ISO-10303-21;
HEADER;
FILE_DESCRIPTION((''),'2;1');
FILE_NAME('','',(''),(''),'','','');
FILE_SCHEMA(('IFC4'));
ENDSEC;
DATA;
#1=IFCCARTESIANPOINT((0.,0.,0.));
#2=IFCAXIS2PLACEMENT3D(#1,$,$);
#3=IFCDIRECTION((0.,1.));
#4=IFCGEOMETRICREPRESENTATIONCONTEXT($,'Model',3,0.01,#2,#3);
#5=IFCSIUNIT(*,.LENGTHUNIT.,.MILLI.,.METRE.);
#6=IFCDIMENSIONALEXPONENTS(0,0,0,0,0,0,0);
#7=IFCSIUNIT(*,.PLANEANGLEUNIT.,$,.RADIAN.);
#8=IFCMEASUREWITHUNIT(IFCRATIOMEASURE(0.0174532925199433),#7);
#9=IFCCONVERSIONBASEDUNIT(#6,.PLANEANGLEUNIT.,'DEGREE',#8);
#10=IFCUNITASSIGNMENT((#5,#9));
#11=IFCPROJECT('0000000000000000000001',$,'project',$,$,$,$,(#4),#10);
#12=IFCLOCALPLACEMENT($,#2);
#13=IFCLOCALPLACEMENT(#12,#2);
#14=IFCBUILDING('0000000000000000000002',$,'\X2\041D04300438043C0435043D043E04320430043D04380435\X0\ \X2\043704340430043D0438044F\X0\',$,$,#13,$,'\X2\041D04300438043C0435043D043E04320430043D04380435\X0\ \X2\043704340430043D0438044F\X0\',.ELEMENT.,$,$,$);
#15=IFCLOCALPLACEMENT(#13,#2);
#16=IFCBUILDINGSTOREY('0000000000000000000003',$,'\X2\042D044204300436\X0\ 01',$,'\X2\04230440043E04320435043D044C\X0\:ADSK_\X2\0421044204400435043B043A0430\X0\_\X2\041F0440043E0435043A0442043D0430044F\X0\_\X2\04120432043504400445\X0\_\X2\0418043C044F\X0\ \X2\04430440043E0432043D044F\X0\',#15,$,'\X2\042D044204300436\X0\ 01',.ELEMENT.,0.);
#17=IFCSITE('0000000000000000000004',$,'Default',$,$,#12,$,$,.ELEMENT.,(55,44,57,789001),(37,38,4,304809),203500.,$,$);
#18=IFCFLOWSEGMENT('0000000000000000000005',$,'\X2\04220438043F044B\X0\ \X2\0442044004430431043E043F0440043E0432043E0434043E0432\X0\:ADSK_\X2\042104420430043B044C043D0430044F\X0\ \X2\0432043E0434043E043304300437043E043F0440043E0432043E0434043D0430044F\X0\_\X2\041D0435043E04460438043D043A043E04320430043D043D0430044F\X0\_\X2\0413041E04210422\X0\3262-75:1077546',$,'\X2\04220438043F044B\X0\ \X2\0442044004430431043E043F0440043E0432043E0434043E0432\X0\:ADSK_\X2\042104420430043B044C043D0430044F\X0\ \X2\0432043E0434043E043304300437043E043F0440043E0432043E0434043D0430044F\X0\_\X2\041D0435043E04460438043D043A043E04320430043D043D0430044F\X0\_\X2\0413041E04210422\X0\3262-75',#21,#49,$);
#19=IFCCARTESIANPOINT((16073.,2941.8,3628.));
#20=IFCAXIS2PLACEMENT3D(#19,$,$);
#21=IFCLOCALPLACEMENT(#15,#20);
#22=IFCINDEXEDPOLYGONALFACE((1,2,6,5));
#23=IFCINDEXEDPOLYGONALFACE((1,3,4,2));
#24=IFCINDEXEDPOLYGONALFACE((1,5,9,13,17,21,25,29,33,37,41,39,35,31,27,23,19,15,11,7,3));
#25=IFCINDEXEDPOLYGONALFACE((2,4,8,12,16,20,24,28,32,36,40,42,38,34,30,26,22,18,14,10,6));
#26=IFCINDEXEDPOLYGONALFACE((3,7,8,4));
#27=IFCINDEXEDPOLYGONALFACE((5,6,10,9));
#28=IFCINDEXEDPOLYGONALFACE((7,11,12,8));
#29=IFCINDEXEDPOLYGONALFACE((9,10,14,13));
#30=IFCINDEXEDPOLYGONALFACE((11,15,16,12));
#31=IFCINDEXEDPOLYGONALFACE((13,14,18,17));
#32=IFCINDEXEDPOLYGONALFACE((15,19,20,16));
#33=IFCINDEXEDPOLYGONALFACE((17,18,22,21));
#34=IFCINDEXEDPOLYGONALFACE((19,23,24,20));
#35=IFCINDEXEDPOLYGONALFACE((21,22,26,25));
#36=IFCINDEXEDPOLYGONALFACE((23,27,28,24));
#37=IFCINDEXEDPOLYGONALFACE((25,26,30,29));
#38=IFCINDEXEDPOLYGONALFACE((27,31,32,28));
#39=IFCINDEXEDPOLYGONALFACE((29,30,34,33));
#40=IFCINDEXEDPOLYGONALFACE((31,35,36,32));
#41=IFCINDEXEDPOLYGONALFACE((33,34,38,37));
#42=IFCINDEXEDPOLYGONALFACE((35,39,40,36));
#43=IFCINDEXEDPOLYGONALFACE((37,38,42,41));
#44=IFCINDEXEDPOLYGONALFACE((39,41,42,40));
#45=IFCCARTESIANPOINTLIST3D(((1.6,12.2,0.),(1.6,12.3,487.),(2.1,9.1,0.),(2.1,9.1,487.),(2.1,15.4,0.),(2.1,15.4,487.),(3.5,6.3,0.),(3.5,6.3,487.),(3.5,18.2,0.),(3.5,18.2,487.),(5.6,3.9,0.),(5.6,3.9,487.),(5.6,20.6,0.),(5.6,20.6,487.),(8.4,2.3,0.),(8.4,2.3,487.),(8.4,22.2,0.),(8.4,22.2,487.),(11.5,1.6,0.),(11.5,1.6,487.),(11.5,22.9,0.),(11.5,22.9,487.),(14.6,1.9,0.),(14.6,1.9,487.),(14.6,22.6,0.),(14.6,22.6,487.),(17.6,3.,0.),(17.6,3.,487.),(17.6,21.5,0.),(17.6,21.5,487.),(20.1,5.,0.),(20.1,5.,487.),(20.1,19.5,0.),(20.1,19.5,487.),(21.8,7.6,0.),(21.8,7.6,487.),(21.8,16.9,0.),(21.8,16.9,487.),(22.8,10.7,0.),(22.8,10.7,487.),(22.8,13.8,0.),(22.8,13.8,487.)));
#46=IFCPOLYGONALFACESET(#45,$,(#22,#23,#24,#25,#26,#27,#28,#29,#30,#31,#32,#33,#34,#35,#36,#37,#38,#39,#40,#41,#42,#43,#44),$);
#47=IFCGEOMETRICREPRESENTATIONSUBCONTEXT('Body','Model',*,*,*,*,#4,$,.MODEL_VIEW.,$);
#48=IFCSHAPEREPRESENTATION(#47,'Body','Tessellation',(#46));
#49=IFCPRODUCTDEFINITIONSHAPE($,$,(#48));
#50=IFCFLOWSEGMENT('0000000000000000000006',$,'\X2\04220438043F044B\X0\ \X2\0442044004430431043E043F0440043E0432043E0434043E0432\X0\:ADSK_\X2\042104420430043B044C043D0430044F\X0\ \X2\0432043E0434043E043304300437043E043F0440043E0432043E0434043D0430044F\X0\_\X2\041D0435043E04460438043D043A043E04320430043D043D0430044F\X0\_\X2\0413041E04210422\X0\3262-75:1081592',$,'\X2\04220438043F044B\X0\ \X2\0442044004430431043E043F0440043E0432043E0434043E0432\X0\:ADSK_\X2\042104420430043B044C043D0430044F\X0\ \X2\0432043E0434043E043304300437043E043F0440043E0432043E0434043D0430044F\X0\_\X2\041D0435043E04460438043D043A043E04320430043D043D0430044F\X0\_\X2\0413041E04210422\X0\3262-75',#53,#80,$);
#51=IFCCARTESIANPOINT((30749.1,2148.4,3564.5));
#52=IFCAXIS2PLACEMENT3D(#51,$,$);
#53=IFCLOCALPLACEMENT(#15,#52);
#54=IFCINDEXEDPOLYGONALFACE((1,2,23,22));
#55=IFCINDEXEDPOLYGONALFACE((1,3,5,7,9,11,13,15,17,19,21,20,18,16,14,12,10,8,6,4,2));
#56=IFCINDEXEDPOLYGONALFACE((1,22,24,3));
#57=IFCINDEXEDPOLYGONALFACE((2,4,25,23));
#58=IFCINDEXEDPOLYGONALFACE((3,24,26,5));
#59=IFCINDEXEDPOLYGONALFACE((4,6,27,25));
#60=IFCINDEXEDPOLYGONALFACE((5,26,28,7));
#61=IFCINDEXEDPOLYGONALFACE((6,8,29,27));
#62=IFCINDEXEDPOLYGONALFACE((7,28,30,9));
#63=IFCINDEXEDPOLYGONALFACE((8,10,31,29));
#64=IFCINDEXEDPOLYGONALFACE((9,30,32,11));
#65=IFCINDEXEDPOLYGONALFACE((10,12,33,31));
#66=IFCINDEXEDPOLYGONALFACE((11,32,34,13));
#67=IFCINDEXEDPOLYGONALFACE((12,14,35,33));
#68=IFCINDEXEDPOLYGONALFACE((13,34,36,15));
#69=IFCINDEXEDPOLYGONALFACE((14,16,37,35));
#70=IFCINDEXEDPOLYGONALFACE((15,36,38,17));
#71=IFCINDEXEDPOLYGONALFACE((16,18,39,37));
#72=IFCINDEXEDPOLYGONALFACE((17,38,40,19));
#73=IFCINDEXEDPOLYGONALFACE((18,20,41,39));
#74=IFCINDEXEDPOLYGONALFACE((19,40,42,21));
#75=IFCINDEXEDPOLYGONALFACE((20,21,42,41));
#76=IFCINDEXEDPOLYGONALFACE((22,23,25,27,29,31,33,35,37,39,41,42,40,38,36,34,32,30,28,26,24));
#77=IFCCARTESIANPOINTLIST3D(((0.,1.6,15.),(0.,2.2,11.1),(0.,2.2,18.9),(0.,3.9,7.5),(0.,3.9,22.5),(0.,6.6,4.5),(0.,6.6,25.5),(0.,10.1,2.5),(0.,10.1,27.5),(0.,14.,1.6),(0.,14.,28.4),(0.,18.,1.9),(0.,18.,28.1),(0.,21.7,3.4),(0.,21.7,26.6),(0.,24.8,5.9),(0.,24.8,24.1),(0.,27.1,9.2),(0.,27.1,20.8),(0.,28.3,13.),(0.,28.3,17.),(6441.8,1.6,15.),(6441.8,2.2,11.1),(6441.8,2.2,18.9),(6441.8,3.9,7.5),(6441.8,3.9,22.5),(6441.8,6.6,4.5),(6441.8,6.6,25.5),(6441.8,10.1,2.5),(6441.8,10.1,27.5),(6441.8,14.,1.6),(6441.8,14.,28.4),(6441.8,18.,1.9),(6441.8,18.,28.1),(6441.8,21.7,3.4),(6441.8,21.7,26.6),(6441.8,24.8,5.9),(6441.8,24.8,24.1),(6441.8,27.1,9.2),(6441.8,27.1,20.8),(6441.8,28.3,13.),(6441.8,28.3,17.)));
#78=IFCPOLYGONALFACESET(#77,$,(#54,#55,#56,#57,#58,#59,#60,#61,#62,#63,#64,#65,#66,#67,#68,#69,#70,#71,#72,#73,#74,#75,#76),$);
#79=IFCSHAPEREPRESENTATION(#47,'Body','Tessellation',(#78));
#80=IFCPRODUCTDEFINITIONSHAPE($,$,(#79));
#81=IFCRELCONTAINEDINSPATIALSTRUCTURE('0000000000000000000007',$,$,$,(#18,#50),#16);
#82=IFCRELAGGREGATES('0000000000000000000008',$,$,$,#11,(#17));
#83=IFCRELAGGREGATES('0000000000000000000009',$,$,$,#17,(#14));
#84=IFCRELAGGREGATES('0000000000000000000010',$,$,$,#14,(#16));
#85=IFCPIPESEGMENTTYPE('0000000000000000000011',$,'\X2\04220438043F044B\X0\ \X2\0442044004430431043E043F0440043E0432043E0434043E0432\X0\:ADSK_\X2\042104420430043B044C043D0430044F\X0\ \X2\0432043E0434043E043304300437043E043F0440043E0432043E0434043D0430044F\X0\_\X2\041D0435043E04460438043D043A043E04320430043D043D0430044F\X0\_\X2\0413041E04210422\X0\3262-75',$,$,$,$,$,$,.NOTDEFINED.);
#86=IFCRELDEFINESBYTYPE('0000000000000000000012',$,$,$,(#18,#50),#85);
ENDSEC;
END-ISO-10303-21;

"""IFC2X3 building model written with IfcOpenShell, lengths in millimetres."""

from ifc_helpers import new_model, entity, si_unit, converted_unit, direction, frame, origin, origin_2d_with_axis, place, context, subcontext, project, spatial, circle, extrude, type_object, element, save


model = new_model("IFC2X3")

# Units and contexts
model_context = context("Model", 3, precision=0.01, world=origin(), true_north=direction((0.0, 1.0)))
body_context = subcontext(model_context, "Body", "Model", "MODEL_VIEW")
ifc_project = project(units=[si_unit("LENGTHUNIT", "METRE", prefix="MILLI"), converted_unit("PLANEANGLEUNIT", "DEGREE", entity("IfcRatioMeasure", 0.0174532925199433), si_unit("PLANEANGLEUNIT", "RADIAN"), dimensions=[0, 0, 0, 0, 0, 0, 0])], contexts=[model_context])

# Site, building, storey
site_placement = place(None, origin())
site = spatial("IfcSite", under=ifc_project, at=site_placement, Name="Default", CompositionType="ELEMENT", RefLatitude=(55, 44, 57, 789001), RefLongitude=(37, 38, 4, 304809), RefElevation=203500.0)
building_placement = place(site_placement, origin())
building = spatial("IfcBuilding", under=site, at=building_placement, Name="Наименование здания", LongName="Наименование здания", CompositionType="ELEMENT")
storey_placement = place(building_placement, origin())
storey = spatial("IfcBuildingStorey", under=building, at=storey_placement, Name="Этаж 01", ObjectType="Уровень:ADSK_Стрелка_Проектная_Вверх_Имя уровня", LongName="Этаж 01", CompositionType="ELEMENT", Elevation=0.0)

# Flow segments
pipe_segment_type = type_object("IfcPipeSegmentType", Name="Типы трубопроводов:ADSK_Стальная водогазопроводная_Неоцинкованная_ГОСТ3262-75", PredefinedType="NOTDEFINED")
flow_segment_1_placement = place(storey_placement, frame((16073.0, 2941.8, 3628.0)))
element("IfcFlowSegment", 1, at=flow_segment_1_placement, inside=storey, type_object=pipe_segment_type, Name="Типы трубопроводов:ADSK_Стальная водогазопроводная_Неоцинкованная_ГОСТ3262-75:1077546", ObjectType="Типы трубопроводов:ADSK_Стальная водогазопроводная_Неоцинкованная_ГОСТ3262-75", context=body_context, shape_type="SweptSolid", body=[
    extrude(circle(Radius=10.7, at=origin_2d_with_axis()), frame((12.2, 12.2, 0.0), z_axis=(0.0, 0.0, 1.0), x_axis=(-1.0, 0.0, 0.0)), (0.0, 0.0, 1.0), 487.0),
])
flow_segment_2_placement = place(storey_placement, frame((30749.1, 2148.4, 3564.5)))
element("IfcFlowSegment", 2, at=flow_segment_2_placement, inside=storey, type_object=pipe_segment_type, Name="Типы трубопроводов:ADSK_Стальная водогазопроводная_Неоцинкованная_ГОСТ3262-75:1081592", ObjectType="Типы трубопроводов:ADSK_Стальная водогазопроводная_Неоцинкованная_ГОСТ3262-75", context=body_context, shape_type="SweptSolid", body=[
    extrude(circle(Radius=13.4, at=origin_2d_with_axis()), frame((0.0, 15.0, 15.0), z_axis=(1.0, 0.0, 0.0), x_axis=(0.0, -1.0, 0.0)), (0.0, 0.0, 1.0), 6441.8),
])

save(model, "model.ifc")
